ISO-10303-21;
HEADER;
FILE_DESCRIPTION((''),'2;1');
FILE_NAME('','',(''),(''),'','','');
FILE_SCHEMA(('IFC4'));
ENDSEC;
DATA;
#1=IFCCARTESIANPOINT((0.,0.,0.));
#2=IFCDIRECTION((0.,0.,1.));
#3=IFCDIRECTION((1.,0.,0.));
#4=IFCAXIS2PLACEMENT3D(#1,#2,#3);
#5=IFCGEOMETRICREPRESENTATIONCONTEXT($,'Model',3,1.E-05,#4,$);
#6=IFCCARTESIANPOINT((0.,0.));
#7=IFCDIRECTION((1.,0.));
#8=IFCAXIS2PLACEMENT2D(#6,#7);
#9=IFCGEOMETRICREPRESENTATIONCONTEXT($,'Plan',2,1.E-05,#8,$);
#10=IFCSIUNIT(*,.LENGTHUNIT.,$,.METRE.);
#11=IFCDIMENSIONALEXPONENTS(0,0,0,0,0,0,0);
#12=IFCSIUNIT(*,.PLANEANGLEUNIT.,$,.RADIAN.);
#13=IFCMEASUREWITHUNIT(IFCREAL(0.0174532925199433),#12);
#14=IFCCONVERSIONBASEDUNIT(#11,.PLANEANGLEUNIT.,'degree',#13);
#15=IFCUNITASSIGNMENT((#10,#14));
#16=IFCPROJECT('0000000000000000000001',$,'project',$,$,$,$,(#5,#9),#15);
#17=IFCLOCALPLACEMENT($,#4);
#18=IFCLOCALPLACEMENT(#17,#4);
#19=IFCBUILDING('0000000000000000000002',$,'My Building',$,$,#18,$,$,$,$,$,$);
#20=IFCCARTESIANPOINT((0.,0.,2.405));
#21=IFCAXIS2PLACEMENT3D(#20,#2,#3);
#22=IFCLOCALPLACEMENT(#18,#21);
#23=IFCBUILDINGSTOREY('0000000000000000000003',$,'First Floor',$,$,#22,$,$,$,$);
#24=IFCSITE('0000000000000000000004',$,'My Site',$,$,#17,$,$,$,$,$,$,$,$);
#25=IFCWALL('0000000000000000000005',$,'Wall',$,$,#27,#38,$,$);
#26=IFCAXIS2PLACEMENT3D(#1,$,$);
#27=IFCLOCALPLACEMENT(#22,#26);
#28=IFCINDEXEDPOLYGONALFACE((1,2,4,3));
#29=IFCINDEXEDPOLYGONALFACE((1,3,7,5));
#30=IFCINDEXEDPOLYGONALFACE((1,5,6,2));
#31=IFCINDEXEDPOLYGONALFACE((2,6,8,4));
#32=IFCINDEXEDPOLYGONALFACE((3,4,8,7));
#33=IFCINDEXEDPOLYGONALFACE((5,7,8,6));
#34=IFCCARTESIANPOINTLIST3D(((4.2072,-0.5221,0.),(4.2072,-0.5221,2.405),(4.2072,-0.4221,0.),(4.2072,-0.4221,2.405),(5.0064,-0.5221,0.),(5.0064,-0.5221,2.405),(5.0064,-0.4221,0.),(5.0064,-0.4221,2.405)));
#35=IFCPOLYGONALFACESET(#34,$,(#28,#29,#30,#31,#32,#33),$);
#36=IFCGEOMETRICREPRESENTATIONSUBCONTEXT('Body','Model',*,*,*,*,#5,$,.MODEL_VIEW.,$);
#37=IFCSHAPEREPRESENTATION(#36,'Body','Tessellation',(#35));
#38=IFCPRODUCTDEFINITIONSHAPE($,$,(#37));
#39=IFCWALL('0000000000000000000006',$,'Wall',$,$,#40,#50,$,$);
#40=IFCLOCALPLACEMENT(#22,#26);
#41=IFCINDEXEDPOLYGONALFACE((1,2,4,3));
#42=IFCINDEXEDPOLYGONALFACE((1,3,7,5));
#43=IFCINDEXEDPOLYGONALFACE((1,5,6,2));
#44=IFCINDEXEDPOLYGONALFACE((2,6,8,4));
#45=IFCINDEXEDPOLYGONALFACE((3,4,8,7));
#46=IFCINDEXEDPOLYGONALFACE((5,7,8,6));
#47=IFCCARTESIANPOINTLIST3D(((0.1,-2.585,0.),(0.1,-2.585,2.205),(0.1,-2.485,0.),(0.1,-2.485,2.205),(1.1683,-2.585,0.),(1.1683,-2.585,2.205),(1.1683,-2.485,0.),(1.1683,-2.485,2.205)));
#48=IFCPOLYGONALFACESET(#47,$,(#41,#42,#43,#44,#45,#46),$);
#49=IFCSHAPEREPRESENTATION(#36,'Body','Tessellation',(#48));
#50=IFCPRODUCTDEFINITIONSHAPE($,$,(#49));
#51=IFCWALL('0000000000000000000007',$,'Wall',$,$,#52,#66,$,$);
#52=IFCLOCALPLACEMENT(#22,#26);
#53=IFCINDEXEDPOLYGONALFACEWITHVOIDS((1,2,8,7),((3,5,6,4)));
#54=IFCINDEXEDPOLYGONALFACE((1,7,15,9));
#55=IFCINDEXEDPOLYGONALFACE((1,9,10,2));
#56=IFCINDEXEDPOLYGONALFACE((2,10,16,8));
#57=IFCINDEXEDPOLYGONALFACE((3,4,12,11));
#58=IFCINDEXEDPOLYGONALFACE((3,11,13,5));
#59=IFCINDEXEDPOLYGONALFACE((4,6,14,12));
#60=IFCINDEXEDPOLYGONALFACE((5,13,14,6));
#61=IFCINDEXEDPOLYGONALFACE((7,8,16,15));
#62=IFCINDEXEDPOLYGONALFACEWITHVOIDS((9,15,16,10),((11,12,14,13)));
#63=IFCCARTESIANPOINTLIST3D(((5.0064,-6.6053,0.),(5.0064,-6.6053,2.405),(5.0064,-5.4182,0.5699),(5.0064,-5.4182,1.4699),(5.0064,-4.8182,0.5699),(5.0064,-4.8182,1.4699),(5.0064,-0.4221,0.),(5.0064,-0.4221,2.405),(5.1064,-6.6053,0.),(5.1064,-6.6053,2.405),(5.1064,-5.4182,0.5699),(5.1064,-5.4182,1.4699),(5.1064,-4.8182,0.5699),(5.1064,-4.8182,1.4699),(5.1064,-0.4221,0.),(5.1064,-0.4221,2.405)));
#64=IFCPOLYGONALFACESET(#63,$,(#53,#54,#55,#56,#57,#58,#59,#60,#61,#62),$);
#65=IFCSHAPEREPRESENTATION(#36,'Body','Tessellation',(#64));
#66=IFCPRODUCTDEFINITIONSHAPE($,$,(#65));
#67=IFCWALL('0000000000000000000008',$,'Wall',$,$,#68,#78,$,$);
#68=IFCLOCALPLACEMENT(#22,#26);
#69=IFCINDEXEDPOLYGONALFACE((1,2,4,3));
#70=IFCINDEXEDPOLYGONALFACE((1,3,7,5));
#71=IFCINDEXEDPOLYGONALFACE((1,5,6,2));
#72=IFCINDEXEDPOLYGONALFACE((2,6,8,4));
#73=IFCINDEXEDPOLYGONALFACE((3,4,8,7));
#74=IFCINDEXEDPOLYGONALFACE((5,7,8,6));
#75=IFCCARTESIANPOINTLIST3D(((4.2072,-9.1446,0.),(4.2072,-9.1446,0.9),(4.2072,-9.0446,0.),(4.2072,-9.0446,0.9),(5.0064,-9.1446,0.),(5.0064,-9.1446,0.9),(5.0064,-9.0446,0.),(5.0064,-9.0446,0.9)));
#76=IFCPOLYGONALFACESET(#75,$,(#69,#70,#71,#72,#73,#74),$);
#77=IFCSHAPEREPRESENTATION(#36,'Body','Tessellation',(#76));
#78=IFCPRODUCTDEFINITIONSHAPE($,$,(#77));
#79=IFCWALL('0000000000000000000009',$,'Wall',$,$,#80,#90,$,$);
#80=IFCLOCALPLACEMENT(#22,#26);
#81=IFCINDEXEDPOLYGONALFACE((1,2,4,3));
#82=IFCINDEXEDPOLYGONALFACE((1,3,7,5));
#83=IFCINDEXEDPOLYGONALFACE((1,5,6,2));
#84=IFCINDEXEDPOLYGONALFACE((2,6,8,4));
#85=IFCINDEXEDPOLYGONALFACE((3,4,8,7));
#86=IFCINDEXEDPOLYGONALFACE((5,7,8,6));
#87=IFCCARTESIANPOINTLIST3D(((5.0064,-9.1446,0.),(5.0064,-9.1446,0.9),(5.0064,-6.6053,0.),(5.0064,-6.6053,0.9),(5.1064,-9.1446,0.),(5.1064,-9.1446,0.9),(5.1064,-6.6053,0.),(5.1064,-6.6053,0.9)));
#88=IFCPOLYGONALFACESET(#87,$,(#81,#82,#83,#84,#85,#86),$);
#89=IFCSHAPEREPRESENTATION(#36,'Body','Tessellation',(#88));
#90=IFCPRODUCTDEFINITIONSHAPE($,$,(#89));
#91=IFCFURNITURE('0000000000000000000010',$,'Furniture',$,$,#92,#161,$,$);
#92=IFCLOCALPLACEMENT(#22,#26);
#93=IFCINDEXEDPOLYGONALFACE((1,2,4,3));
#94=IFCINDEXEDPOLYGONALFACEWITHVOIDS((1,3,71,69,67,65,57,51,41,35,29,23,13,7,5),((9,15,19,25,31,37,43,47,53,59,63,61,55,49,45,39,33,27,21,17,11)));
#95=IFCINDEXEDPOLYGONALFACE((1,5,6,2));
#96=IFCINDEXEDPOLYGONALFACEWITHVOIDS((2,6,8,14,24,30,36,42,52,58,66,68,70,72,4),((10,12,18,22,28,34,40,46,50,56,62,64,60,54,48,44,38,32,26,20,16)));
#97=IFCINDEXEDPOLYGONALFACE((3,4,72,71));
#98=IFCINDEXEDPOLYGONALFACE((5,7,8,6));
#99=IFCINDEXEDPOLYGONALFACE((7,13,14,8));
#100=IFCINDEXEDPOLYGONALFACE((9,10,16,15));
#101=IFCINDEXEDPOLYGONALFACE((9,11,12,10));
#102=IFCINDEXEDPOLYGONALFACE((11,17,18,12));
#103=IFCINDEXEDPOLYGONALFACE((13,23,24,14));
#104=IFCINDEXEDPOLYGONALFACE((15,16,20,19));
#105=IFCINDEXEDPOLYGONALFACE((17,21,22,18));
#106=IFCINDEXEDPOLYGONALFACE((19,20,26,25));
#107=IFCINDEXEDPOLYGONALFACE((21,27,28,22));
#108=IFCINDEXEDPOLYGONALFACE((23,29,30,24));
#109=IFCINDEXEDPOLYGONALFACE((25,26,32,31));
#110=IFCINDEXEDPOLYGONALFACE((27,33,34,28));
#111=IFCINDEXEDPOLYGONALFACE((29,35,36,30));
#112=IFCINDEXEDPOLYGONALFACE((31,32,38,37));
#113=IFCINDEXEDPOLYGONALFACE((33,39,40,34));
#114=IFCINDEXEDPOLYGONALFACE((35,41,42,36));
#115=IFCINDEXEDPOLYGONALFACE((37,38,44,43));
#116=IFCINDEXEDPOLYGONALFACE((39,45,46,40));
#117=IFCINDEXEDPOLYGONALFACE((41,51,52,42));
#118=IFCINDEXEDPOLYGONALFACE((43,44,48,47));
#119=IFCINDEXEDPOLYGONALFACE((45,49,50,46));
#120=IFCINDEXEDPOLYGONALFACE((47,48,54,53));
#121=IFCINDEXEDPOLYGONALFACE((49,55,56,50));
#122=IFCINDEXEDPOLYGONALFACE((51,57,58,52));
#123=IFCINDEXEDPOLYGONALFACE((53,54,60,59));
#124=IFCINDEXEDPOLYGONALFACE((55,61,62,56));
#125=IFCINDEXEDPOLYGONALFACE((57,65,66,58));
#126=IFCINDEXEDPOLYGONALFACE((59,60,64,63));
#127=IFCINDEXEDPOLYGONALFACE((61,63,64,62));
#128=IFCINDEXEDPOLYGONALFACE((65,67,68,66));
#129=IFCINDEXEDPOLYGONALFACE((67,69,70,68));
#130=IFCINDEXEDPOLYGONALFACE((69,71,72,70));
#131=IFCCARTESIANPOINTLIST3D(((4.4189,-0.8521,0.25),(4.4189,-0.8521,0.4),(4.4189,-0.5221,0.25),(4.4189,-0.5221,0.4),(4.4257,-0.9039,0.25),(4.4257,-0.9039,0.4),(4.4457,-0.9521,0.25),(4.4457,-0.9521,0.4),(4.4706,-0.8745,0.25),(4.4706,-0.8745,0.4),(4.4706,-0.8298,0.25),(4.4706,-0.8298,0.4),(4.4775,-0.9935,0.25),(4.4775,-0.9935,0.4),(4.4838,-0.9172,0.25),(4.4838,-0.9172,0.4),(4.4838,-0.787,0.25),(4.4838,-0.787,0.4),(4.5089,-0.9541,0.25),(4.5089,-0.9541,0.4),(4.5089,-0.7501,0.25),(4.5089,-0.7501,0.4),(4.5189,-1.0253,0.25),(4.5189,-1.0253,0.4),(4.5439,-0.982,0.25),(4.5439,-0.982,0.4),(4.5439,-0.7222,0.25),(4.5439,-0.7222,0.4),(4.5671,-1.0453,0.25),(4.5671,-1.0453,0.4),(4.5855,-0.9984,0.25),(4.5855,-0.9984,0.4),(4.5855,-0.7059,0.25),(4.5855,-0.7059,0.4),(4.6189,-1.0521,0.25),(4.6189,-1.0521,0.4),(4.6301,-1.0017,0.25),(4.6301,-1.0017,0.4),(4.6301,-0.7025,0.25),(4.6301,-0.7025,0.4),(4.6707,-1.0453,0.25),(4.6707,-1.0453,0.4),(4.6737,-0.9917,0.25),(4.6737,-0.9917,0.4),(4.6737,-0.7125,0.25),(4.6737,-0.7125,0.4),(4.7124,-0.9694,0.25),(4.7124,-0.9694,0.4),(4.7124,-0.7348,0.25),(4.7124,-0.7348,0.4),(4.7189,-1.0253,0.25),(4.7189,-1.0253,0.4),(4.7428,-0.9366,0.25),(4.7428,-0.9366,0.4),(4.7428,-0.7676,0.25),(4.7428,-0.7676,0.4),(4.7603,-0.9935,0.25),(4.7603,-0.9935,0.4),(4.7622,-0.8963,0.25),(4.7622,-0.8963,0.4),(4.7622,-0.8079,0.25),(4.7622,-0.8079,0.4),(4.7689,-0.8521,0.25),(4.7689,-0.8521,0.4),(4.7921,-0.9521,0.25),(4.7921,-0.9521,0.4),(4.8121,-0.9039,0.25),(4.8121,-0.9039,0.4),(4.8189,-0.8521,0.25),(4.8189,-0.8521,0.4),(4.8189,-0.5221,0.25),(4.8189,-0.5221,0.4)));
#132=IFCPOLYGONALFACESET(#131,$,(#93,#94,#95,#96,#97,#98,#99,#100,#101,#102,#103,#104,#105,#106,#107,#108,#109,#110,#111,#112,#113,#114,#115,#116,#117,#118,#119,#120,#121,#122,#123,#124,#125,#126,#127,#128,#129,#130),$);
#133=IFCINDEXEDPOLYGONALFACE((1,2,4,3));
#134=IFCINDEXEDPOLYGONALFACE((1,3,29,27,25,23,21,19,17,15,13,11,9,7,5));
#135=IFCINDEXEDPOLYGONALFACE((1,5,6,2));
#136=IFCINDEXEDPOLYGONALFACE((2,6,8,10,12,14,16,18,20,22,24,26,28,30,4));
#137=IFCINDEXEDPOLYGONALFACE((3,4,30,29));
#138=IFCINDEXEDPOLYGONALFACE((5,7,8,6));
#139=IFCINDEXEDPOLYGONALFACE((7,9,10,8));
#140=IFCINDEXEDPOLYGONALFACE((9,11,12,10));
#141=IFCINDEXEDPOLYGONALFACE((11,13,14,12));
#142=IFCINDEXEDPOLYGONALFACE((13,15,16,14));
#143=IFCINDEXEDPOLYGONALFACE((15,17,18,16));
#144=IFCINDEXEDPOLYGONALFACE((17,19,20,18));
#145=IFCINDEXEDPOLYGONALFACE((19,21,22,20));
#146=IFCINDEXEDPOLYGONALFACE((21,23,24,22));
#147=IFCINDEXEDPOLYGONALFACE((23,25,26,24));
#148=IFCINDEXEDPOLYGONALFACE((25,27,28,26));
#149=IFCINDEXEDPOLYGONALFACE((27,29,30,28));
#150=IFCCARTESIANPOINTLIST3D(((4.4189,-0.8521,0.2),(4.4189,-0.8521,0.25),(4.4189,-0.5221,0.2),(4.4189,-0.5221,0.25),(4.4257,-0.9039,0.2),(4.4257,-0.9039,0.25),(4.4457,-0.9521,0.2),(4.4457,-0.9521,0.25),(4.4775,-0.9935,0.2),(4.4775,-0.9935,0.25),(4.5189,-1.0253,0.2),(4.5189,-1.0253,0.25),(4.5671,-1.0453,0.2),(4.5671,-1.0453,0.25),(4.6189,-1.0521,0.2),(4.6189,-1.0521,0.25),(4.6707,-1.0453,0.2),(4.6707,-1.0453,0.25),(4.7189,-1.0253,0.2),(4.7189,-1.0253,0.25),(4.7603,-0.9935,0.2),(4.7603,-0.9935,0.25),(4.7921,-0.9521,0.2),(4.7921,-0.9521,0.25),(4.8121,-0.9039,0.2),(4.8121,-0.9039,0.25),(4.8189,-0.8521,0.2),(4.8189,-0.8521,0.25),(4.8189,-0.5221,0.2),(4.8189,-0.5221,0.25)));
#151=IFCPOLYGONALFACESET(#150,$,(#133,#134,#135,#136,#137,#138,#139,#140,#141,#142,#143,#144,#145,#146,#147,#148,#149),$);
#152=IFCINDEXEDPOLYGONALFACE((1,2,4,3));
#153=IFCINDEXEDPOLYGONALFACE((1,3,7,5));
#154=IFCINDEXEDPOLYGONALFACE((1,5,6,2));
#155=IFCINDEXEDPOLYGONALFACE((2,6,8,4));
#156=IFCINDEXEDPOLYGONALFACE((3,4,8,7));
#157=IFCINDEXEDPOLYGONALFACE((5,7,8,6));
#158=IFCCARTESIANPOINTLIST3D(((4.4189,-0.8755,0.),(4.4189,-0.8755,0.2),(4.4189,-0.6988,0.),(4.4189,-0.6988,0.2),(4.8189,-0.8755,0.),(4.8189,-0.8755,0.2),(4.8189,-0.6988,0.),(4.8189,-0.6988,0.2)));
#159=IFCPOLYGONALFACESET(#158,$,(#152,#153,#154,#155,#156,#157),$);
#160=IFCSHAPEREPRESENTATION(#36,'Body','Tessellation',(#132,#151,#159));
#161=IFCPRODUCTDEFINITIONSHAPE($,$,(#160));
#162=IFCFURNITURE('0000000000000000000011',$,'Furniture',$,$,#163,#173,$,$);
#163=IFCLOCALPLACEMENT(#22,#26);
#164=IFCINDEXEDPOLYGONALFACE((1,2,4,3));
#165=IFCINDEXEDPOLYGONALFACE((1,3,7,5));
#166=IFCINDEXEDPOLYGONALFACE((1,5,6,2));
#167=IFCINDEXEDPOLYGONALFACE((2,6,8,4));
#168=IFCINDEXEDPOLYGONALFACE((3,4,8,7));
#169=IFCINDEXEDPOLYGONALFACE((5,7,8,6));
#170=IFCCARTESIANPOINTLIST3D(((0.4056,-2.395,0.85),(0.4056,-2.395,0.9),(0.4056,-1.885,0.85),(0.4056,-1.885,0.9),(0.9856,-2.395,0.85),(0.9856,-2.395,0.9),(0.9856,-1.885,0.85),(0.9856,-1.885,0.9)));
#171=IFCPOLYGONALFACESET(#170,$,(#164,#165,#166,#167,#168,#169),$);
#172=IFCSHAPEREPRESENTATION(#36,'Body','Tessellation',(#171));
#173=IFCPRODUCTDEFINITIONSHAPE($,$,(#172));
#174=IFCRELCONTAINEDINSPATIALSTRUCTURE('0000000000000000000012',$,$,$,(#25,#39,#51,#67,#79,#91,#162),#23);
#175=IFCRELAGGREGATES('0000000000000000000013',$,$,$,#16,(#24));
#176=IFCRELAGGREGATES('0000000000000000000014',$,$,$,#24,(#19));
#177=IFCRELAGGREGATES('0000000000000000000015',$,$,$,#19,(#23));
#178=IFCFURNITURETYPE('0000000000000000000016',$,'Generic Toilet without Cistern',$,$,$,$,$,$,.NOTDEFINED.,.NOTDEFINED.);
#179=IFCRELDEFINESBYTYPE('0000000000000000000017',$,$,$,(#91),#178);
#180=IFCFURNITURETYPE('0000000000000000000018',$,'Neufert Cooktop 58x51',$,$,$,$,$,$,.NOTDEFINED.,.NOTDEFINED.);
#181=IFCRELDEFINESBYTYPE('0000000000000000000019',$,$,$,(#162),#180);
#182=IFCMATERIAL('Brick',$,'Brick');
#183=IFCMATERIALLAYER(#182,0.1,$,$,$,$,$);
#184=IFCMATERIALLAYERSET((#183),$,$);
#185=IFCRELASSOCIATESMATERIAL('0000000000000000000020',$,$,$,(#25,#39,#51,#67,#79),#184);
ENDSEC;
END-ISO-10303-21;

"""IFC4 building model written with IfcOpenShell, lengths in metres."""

from ifc_helpers import new_model, entity, si_unit, converted_unit, frame, frame_2d, origin_with_axes, origin_2d_with_axis, place, context, subcontext, project, spatial, line, arc, indexed_curve, circle_curve, outline, extrude, source, transform, mapped, material, layer, layer_set, layer_usage, type_object, type_shapes, element, save


model = new_model("IFC4")

# Units and contexts
model_context = context("Model", 3, precision=1e-05, world=origin_with_axes())
plan_context = context("Plan", 2, precision=1e-05, world=origin_2d_with_axis())
body_context = subcontext(model_context, "Body", "Model", "MODEL_VIEW")
ifc_project = project(units=[si_unit("LENGTHUNIT", "METRE"), converted_unit("PLANEANGLEUNIT", "degree", entity("IfcReal", 0.0174532925199433), si_unit("PLANEANGLEUNIT", "RADIAN"), dimensions=[0, 0, 0, 0, 0, 0, 0])], contexts=[model_context, plan_context])

# Site, building, storey
site_placement = place(None, origin_with_axes())
site = spatial("IfcSite", under=ifc_project, at=site_placement, Name="My Site")
building_placement = place(site_placement, origin_with_axes())
building = spatial("IfcBuilding", under=site, at=building_placement, Name="My Building")
storey_placement = place(building_placement, frame((0.0, 0.0, 2.405), z_axis=(0.0, 0.0, 1.0), x_axis=(1.0, 0.0, 0.0)))
storey = spatial("IfcBuildingStorey", under=building, at=storey_placement, Name="First Floor")

# Shared definitions
ifc_material_1 = material(Name="Brick", Category="Brick")
ifc_layer_1 = layer(ifc_material_1, 0.1)
ifc_layer_set_1 = layer_set([ifc_layer_1])

# Shared definitions
shared_shape_1 = source(origin_with_axes(), body_context, "Body", "SweptSolid", [
    extrude(outline(indexed_curve([(0.0, 0.0), (0.6, 0.0), (0.6, 0.9), (0.0, 0.9)], segments=[line(1, 2, 3, 4, 1)])), frame((0.0, -0.1, 0.0), z_axis=(0.0, -1.0, 0.0), x_axis=(1.0, 0.0, 0.0)), (0.0, 0.0, -1.0), 0.3),
])

# Walls
ifc_layer_usage_1 = layer_usage(ifc_layer_set_1, "AXIS2", "POSITIVE", 0.0)
wall_1_placement = place(storey_placement, frame((5.0064, -0.4221, 0.0), z_axis=(0.0, 0.0, 1.0), x_axis=(-1.0, 0.000001, 0.0)))
element("IfcWall", 1, at=wall_1_placement, inside=storey, material=ifc_layer_usage_1, Name="Wall", context=body_context, shape_type="SweptSolid", body=[
    extrude(outline(indexed_curve([(0.0, 0.0), (0.0, 0.1), (0.7992, 0.1), (0.7992, 0.0), (0.0, 0.0)], self_intersect=False)), origin_with_axes(), (0.0, 0.0, 1.0), 2.405),
])
ifc_layer_usage_2 = layer_usage(ifc_layer_set_1, "AXIS2", "POSITIVE", 0.0)
wall_2_placement = place(storey_placement, frame((1.1683, -2.485, 0.0), z_axis=(0.0, 0.0, 1.0), x_axis=(-1.0, 0.0, 0.0)))
element("IfcWall", 2, at=wall_2_placement, inside=storey, material=ifc_layer_usage_2, Name="Wall", context=body_context, shape_type="SweptSolid", body=[
    extrude(outline(indexed_curve([(0.0, 0.0), (0.0, 0.1), (1.0683, 0.1), (1.0683, 0.0), (0.0, 0.0)], self_intersect=False)), origin_with_axes(), (0.0, 0.0, 1.0), 2.205),
])

# Wall, opening
ifc_layer_usage_3 = layer_usage(ifc_layer_set_1, "AXIS2", "POSITIVE", 0.0)
wall_3_placement = place(storey_placement, frame((5.1064, -6.6053, 0.0), z_axis=(0.0, 0.0, 1.0), x_axis=(0.000001, 1.0, 0.0)))
wall_3 = element("IfcWall", 3, at=wall_3_placement, inside=storey, material=ifc_layer_usage_3, Name="Wall", context=body_context, shape_type="SweptSolid", body=[
    extrude(outline(indexed_curve([(0.0, 0.0), (0.0, 0.1), (6.1832, 0.1), (6.1832, 0.0), (0.0, 0.0)], self_intersect=False)), origin_with_axes(), (0.0, 0.0, 1.0), 2.405),
])
opening_1_placement = place(wall_3_placement, frame((1.1871, 0.0, 0.5699), z_axis=(0.0, 0.0, 1.0), x_axis=(1.0, 0.0, 0.0)))
element("IfcOpeningElement", 4, at=opening_1_placement, cuts=wall_3, PredefinedType="OPENING", context=body_context, shape_type="MappedRepresentation", body=[
    mapped(shared_shape_1, transform((0.0, 0.0, 0.0), x_axis=(1.0, 0.0, 0.0), y_axis=(0.0, 1.0, 0.0), z_axis=(0.0, 0.0, 1.0), scale=1.0)),
])

# Walls
ifc_layer_usage_4 = layer_usage(ifc_layer_set_1, "AXIS2", "POSITIVE", 0.0)
wall_4_placement = place(storey_placement, frame((4.2072, -9.1446, 0.0), z_axis=(0.0, 0.0, 1.0), x_axis=(1.0, 0.0, 0.0)))
element("IfcWall", 5, at=wall_4_placement, inside=storey, material=ifc_layer_usage_4, Name="Wall", context=body_context, shape_type="SweptSolid", body=[
    extrude(outline(indexed_curve([(0.0, 0.0), (0.0, 0.1), (0.7992, 0.1), (0.7992, 0.0), (0.0, 0.0)], self_intersect=False)), origin_with_axes(), (0.0, 0.0, 1.0), 0.9),
])
ifc_layer_usage_5 = layer_usage(ifc_layer_set_1, "AXIS2", "POSITIVE", 0.0)
wall_5_placement = place(storey_placement, frame((5.1064, -9.1446, 0.0), z_axis=(0.0, 0.0, 1.0), x_axis=(0.000001, 1.0, 0.0)))
element("IfcWall", 6, at=wall_5_placement, inside=storey, material=ifc_layer_usage_5, Name="Wall", context=body_context, shape_type="SweptSolid", body=[
    extrude(outline(indexed_curve([(0.0, 0.0), (0.0, 0.1), (2.5394, 0.1), (2.5394, 0.0), (0.0, 0.0)], self_intersect=False)), origin_with_axes(), (0.0, 0.0, 1.0), 0.9),
])

# Furniture
furniture_type_1 = type_object("IfcFurnitureType", Name="Generic Toilet without Cistern", AssemblyPlace="NOTDEFINED", PredefinedType="NOTDEFINED")
shared_shape_2 = source(origin_with_axes(), body_context, "Body", "SweptSolid", [
    extrude(outline(indexed_curve([(-0.2, 0.0, 0.0), (-0.2, -0.33, 0.0), (-0.1414, -0.4714, 0.0), (0.0, -0.53, 0.0), (0.1414, -0.4714, 0.0), (0.2, -0.33, 0.0), (0.2, 0.0, 0.0)], segments=[line(1, 2), arc(2, 3, 4), arc(4, 5, 6), line(6, 7), line(1, 7)]), holes=[circle_curve(frame_2d((0.0, -0.33)), 0.15)]), frame((0.0, 0.0, 0.25), z_axis=(0.0, 0.0, 1.0), x_axis=(1.0, 0.0, 0.0)), (0.0, 0.0, 1.0), 0.15),
    extrude(outline(indexed_curve([(-0.2, 0.0, 0.0), (-0.2, -0.33, 0.0), (-0.1414, -0.4714, 0.0), (0.0, -0.53, 0.0), (0.1414, -0.4714, 0.0), (0.2, -0.33, 0.0), (0.2, 0.0, 0.0)], segments=[line(1, 2), arc(2, 3, 4), arc(4, 5, 6), line(6, 7), line(1, 7)])), frame((0.0, 0.0, 0.2), z_axis=(0.0, 0.0, 1.0), x_axis=(1.0, 0.0, 0.0)), (0.0, 0.0, 1.0), 0.05),
    extrude(outline(indexed_curve([(-0.2, -0.1767, 0.0), (-0.2, -0.3533, 0.0), (0.2, -0.3533, 0.0), (0.2, -0.1767, 0.0)], segments=[line(1, 2), line(2, 3), line(3, 4), line(4, 1)])), origin_with_axes(), (0.0, 0.0, 1.0), 0.2),
])
type_shapes(furniture_type_1, [shared_shape_2])
furniture_1_placement = place(storey_placement, frame((4.6189, -0.5221, 0.0), z_axis=(0.0, 0.0, 1.0), x_axis=(1.0, 0.0, 0.0)))
element("IfcFurniture", 7, at=furniture_1_placement, inside=storey, type_object=furniture_type_1, Name="Furniture", context=body_context, shape_type="MappedRepresentation", body=[
    mapped(shared_shape_2, transform((0.0, 0.0, 0.0), x_axis=(1.0, 0.0, 0.0), y_axis=(0.0, 1.0, 0.0), z_axis=(0.0, 0.0, 1.0), scale=1.0)),
])
furniture_type_2 = type_object("IfcFurnitureType", Name="Neufert Cooktop 58x51", AssemblyPlace="NOTDEFINED", PredefinedType="NOTDEFINED")
shared_shape_3 = source(origin_with_axes(), body_context, "Body", "SweptSolid", [
    extrude(outline(indexed_curve([(0.0, 0.0), (0.0, 0.51), (0.58, 0.51), (0.58, 0.0)], segments=[line(1, 2), line(2, 3), line(3, 4), line(4, 1)])), origin_with_axes(), (0.0, 0.0, 1.0), 0.05),
])
type_shapes(furniture_type_2, [shared_shape_3])
furniture_2_placement = place(storey_placement, frame((0.4056, -2.395, 0.85), z_axis=(0.0, 0.0, 1.0), x_axis=(1.0, 0.0, 0.0)))
element("IfcFurniture", 8, at=furniture_2_placement, inside=storey, type_object=furniture_type_2, Name="Furniture", context=body_context, shape_type="MappedRepresentation", body=[
    mapped(shared_shape_3, transform((0.0, 0.0, 0.0), x_axis=(1.0, 0.0, 0.0), y_axis=(0.0, 1.0, 0.0), z_axis=(0.0, 0.0, 1.0), scale=1.0)),
])

save(model, "model.ifc")
